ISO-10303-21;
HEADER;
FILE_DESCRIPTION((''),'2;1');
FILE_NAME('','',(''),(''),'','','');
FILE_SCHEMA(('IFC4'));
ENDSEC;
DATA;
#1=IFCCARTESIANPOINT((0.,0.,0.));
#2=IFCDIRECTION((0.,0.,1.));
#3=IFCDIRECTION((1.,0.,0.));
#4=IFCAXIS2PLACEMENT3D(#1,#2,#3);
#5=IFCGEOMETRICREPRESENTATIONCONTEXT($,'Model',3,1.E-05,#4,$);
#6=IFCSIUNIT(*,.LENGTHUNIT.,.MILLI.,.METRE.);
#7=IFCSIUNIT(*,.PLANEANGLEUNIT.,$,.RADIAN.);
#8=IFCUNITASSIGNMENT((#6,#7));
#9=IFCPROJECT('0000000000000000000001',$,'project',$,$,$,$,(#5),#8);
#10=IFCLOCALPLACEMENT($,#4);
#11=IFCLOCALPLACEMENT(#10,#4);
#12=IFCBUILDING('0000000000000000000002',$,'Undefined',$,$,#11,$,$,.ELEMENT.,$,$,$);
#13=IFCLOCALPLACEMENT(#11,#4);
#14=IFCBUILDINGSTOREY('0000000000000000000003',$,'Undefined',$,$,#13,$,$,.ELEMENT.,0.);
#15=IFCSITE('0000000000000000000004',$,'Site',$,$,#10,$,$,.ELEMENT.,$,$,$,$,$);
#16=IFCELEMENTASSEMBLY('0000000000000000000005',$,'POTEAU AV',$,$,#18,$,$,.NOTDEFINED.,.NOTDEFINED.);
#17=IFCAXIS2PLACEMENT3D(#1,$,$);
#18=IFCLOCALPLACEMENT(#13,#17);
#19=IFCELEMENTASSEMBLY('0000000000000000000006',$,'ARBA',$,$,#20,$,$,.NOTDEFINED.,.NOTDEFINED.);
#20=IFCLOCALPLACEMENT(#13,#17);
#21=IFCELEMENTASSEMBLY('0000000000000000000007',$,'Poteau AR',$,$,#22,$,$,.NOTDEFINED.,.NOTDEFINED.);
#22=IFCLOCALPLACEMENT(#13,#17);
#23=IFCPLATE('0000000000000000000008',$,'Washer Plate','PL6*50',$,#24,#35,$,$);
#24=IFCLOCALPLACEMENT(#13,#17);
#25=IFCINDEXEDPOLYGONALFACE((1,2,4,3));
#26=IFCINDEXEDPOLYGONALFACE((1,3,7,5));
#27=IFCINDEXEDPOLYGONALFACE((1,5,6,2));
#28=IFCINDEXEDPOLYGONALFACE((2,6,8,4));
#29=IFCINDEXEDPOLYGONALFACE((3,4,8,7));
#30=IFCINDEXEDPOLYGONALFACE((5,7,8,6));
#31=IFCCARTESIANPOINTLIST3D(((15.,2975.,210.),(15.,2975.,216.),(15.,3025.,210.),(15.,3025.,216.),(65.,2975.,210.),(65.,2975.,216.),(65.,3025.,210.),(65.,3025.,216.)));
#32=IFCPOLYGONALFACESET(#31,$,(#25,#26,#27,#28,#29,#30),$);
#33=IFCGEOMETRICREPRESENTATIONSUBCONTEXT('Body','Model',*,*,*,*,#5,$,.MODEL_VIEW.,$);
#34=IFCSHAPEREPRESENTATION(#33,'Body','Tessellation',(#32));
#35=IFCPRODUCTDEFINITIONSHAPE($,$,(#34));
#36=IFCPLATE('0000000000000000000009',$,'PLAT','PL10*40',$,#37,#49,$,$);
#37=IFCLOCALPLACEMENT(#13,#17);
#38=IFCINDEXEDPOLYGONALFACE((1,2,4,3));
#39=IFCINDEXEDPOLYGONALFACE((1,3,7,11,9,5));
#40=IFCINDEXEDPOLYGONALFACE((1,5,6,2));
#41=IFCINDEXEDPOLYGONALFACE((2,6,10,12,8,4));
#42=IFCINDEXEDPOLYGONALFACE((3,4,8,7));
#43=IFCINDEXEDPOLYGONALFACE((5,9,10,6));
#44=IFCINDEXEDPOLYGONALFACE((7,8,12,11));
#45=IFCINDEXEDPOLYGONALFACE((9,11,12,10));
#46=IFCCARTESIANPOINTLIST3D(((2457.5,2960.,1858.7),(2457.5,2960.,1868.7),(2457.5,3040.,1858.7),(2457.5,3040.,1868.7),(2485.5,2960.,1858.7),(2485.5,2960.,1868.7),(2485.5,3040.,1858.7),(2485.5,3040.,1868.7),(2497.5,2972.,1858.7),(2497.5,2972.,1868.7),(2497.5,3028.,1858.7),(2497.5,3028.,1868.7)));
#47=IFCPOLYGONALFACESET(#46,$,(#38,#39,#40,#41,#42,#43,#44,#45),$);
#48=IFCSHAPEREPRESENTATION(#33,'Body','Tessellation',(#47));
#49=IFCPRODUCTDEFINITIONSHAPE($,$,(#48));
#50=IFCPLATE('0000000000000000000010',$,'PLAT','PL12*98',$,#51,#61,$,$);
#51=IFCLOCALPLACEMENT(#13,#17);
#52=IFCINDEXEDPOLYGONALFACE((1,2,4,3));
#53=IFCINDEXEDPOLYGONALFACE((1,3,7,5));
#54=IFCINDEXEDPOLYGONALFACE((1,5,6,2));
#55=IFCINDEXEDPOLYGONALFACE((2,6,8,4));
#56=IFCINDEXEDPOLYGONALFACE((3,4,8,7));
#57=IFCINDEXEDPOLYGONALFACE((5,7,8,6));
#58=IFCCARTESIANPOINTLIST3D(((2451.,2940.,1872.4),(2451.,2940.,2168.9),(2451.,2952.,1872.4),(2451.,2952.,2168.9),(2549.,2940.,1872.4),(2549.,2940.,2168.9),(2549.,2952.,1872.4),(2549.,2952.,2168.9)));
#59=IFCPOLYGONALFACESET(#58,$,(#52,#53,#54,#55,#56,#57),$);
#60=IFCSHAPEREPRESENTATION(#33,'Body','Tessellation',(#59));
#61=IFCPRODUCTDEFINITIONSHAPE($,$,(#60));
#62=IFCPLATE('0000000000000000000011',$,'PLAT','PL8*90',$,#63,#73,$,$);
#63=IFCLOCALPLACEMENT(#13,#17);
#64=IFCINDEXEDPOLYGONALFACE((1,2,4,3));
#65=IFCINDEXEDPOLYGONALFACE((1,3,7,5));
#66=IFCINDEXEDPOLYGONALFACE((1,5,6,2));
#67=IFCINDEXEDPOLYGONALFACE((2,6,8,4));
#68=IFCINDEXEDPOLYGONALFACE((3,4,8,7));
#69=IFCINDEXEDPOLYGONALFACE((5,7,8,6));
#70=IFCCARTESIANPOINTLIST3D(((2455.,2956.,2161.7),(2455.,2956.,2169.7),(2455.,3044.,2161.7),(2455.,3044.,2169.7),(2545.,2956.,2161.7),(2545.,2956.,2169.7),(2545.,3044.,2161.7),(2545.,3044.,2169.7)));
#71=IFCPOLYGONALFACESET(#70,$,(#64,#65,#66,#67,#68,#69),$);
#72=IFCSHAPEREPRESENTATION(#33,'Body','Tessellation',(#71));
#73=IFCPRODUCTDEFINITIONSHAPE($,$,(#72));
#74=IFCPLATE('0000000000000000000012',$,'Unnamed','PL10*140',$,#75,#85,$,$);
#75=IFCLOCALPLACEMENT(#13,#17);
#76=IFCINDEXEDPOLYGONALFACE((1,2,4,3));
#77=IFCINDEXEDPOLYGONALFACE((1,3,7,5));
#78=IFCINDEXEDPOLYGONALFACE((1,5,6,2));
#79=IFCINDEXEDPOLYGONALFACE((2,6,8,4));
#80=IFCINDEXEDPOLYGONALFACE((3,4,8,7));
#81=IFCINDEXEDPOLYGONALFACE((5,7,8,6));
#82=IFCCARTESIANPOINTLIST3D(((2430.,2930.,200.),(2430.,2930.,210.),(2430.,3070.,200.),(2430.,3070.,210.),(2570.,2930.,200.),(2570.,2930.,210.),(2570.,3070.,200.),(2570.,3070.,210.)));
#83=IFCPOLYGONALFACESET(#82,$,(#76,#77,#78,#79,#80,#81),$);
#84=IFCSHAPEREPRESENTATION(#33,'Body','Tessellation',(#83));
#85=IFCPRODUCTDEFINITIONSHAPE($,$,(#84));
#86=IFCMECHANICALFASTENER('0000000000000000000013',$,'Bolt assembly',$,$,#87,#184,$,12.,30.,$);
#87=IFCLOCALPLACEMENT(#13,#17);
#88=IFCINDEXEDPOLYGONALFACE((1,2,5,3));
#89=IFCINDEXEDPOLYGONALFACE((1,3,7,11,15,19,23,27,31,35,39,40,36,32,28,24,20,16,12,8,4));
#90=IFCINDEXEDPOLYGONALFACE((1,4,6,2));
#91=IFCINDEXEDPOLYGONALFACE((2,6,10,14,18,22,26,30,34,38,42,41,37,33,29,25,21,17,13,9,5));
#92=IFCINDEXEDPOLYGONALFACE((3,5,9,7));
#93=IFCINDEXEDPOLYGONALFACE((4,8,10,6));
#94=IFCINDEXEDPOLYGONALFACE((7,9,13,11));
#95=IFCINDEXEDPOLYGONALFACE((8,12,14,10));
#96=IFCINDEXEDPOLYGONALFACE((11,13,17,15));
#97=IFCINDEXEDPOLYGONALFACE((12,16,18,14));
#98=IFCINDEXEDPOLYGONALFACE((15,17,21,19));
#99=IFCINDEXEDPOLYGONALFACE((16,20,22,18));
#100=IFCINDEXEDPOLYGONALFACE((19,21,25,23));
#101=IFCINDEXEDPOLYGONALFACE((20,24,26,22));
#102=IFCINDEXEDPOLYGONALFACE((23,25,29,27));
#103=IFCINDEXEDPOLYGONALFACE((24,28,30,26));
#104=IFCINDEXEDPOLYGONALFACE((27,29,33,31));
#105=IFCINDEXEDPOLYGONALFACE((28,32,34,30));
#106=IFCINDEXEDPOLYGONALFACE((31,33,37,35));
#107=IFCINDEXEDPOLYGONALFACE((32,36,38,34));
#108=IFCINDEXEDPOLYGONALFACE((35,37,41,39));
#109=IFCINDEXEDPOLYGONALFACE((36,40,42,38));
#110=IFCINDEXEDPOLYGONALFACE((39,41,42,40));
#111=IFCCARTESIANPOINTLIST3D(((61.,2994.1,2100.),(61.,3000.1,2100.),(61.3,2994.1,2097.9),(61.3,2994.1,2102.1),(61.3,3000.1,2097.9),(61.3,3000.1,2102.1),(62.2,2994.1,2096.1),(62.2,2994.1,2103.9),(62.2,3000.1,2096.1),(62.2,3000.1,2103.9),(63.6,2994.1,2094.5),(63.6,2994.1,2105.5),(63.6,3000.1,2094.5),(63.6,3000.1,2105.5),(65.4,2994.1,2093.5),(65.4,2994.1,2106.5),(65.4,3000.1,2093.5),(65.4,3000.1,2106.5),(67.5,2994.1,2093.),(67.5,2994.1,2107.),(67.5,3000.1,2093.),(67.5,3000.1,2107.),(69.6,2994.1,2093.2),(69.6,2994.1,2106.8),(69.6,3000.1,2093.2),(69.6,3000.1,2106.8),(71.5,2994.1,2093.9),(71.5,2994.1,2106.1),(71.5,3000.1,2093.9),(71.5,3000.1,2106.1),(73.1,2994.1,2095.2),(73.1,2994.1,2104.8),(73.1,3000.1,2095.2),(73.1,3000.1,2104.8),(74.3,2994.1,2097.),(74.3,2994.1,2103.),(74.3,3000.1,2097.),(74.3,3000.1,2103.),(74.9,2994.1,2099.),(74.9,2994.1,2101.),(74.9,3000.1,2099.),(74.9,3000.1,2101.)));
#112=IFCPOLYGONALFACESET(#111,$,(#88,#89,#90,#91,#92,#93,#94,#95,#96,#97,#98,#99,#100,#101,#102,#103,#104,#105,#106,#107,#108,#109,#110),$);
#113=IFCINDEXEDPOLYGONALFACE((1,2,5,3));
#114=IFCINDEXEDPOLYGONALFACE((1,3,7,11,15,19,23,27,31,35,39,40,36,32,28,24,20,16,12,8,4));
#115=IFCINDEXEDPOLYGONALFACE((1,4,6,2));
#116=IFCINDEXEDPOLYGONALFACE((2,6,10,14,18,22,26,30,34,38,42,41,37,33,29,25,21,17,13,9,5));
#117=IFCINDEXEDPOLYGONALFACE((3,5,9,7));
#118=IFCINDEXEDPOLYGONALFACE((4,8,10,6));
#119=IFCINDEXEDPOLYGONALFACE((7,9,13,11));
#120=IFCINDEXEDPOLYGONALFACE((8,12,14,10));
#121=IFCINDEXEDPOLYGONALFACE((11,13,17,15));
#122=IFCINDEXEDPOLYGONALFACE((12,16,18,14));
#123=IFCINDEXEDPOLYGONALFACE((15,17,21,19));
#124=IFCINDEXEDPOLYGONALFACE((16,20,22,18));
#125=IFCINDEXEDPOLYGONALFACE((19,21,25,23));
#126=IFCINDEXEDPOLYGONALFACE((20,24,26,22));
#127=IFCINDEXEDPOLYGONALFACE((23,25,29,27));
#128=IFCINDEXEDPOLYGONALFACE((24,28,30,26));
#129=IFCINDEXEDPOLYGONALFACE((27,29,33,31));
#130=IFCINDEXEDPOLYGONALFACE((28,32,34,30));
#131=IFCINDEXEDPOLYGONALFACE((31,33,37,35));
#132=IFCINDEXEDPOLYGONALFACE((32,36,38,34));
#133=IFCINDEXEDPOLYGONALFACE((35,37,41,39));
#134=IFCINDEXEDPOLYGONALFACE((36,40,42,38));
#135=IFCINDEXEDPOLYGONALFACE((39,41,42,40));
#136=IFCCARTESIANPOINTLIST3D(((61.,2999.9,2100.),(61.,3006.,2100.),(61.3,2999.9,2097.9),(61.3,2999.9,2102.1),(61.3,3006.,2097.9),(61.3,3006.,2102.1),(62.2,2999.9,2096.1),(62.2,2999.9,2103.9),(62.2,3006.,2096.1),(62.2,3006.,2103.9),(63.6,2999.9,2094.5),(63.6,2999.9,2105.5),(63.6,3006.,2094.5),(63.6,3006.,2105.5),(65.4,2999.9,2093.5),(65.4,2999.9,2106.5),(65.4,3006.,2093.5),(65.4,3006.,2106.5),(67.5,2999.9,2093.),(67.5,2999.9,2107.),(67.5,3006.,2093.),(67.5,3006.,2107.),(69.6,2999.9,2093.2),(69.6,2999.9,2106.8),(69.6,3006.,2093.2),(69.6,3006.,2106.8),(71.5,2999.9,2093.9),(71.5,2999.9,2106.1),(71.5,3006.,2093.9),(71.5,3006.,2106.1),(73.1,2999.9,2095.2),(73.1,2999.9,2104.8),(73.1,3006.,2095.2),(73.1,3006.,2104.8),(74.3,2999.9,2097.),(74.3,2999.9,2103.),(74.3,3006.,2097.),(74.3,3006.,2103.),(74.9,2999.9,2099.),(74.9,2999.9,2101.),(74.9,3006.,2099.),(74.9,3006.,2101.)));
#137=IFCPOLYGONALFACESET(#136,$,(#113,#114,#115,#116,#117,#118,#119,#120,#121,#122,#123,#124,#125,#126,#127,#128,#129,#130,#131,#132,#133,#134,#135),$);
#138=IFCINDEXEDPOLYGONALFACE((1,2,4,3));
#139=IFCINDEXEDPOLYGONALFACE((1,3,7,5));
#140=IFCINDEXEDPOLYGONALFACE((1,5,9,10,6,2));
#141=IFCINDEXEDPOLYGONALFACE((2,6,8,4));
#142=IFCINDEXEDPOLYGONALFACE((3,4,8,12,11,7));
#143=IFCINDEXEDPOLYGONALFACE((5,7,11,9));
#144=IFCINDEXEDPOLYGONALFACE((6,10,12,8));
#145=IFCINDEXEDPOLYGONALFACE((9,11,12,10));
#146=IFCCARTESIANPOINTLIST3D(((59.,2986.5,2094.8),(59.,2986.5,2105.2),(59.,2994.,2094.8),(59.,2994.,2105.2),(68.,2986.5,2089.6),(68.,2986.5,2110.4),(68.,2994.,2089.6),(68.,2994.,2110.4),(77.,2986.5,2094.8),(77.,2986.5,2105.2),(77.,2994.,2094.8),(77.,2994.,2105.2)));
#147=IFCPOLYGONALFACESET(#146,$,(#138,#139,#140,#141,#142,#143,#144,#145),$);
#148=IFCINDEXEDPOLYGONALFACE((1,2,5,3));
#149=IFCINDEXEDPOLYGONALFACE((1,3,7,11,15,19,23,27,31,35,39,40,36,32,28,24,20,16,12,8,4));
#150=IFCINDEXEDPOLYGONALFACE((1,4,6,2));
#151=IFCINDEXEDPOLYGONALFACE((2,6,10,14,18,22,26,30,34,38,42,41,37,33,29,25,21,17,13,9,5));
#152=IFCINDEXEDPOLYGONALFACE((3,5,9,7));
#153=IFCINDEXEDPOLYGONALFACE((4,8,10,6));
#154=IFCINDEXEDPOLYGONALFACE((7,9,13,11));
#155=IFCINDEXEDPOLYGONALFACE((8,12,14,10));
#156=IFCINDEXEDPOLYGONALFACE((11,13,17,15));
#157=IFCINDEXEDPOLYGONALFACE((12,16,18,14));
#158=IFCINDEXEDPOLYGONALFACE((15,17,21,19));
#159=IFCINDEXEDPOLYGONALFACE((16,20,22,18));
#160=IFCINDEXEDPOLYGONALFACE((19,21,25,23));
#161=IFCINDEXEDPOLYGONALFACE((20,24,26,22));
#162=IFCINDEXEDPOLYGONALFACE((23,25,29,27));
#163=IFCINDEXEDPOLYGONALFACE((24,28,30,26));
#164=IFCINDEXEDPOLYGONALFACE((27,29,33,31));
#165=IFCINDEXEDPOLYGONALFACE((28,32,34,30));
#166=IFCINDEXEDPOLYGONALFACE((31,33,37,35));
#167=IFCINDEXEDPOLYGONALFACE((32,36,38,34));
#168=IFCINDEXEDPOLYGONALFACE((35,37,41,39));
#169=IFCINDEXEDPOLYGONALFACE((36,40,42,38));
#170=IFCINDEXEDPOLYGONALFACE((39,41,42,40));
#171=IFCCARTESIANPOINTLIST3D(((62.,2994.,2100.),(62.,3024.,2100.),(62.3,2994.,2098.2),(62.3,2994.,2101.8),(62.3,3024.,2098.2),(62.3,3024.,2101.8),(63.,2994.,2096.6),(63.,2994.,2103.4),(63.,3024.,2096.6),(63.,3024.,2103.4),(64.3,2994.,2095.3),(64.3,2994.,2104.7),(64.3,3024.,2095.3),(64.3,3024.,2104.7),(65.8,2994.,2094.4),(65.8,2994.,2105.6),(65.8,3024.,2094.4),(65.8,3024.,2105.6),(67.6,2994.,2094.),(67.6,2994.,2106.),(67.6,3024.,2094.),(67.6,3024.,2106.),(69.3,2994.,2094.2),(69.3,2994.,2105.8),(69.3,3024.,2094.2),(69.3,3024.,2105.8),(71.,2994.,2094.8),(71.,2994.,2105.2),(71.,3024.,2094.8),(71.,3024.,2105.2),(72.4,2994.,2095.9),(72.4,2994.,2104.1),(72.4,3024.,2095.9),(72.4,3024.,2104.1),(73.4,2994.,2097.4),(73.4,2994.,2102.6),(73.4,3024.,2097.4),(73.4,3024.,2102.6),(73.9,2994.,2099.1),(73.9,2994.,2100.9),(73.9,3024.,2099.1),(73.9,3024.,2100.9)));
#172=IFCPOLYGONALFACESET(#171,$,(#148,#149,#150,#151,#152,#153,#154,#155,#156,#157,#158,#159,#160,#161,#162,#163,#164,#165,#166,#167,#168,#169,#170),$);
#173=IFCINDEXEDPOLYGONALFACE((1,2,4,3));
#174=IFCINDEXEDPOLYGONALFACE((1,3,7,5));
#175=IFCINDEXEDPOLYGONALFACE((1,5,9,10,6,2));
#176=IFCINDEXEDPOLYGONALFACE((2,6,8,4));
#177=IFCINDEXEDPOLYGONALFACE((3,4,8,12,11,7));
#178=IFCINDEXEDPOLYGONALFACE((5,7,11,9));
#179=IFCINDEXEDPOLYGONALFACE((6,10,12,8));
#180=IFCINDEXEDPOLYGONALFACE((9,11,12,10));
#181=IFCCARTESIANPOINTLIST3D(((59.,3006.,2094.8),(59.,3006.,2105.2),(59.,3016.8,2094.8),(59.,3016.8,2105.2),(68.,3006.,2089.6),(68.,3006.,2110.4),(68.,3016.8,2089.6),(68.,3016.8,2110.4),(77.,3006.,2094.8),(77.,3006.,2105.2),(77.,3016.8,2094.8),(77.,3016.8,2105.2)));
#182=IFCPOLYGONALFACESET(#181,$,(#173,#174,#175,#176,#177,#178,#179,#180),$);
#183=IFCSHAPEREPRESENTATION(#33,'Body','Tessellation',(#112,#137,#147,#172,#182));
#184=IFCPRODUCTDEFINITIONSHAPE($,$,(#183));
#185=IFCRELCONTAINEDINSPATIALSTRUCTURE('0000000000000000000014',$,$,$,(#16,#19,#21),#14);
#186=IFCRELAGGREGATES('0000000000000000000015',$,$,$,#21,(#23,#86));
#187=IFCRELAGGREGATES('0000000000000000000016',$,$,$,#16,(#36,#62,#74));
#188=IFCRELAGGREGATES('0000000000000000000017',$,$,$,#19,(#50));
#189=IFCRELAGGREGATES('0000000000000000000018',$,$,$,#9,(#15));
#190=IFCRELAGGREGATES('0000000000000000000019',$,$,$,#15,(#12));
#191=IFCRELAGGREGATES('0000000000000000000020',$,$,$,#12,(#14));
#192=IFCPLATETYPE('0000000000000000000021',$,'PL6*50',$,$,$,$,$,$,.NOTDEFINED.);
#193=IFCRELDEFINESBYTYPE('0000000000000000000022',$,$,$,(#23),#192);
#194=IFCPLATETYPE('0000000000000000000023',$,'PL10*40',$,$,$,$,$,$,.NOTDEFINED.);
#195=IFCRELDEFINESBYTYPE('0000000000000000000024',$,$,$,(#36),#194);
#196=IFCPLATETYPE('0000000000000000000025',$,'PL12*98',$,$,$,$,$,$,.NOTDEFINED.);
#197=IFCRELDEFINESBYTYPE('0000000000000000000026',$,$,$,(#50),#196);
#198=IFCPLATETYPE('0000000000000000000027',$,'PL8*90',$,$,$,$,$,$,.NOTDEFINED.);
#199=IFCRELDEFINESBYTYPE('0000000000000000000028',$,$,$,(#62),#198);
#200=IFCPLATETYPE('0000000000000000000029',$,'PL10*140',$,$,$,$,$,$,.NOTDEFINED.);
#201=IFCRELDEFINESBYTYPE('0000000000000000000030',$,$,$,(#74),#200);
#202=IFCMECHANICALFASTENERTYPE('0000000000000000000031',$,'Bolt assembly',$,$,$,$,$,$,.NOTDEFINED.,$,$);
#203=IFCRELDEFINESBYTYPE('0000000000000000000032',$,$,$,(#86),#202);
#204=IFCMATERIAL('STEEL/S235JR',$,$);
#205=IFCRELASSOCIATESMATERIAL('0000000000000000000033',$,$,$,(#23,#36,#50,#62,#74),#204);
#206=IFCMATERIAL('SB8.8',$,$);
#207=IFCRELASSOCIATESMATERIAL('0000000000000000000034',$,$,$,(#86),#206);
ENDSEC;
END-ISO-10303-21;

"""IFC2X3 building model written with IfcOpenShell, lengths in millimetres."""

from ifc_helpers import new_model, si_unit, frame, origin_with_axes, origin_2d_with_axis, place, context, subcontext, project, spatial, polyline, circle, outline, extrude, source, transform, mapped, material, type_object, element, aggregate, save


model = new_model("IFC2X3")

# Units and contexts
model_context = context("Model", 3, precision=1e-05, world=origin_with_axes())
body_context = subcontext(model_context, "Body", "Model", "MODEL_VIEW")
ifc_project = project(units=[si_unit("LENGTHUNIT", "METRE", prefix="MILLI"), si_unit("PLANEANGLEUNIT", "RADIAN")], contexts=[model_context])

# Site, building, storey
site_placement = place(None, origin_with_axes())
site = spatial("IfcSite", under=ifc_project, at=site_placement, Name="Site", CompositionType="ELEMENT")
building_placement = place(site_placement, origin_with_axes())
building = spatial("IfcBuilding", under=site, at=building_placement, Name="Undefined", CompositionType="ELEMENT")
storey_placement = place(building_placement, origin_with_axes())
storey = spatial("IfcBuildingStorey", under=building, at=storey_placement, Name="Undefined", CompositionType="ELEMENT", Elevation=0.0)

# Element assembly
ifc_material_1 = material(Name="STEEL/S235JR")
assembly_1_placement = place(storey_placement, origin_with_axes())
assembly_1 = element("IfcElementAssembly", 1, at=assembly_1_placement, inside=storey, Name="POTEAU AV", AssemblyPlace="NOTDEFINED", PredefinedType="NOTDEFINED")

# Element assembly
assembly_2_placement = place(storey_placement, origin_with_axes())
assembly_2 = element("IfcElementAssembly", 2, at=assembly_2_placement, inside=storey, Name="ARBA", AssemblyPlace="NOTDEFINED", PredefinedType="NOTDEFINED")

# Element assembly
assembly_3_placement = place(storey_placement, origin_with_axes())
assembly_3 = element("IfcElementAssembly", 3, at=assembly_3_placement, inside=storey, Name="Poteau AR", AssemblyPlace="NOTDEFINED", PredefinedType="NOTDEFINED")

# Shared definitions
plate_type_1 = type_object("IfcPlateType", Name="PL6*50", PredefinedType="NOTDEFINED")

# Plates
plate_1_placement = place(assembly_3_placement, frame((65.0, 3025.0, 213.0), z_axis=(0.0, 0.0, -1.0), x_axis=(0.0, -1.0, 0.0)))
plate_1 = element("IfcPlate", 4, at=plate_1_placement, type_object=plate_type_1, material=ifc_material_1, Name="Washer Plate", Description="PL6*50", context=body_context, shape_type="SweptSolid", body=[
    extrude(outline(polyline([(0.0, 0.0), (50.0, 0.0), (50.0, 50.0), (0.0, 50.0), (0.0, 0.0)])), frame((0.0, 0.0, -3.0), z_axis=(0.0, 0.0, 1.0), x_axis=(1.0, 0.0, 0.0)), (0.0, 0.0, 1.0), 6.0),
])
plate_type_2 = type_object("IfcPlateType", Name="PL10*40", PredefinedType="NOTDEFINED")
plate_2_placement = place(assembly_1_placement, frame((2457.5, 2960.0, 1863.7), z_axis=(0.0, 0.0, 1.0), x_axis=(1.0, 0.0, 0.0)))
plate_2 = element("IfcPlate", 5, at=plate_2_placement, type_object=plate_type_2, material=ifc_material_1, Name="PLAT", Description="PL10*40", context=body_context, shape_type="SweptSolid", body=[
    extrude(outline(polyline([(0.0, 0.0), (28.0, 0.0), (40.0, 12.0), (40.0, 68.0), (28.0, 80.0), (0.0, 80.0), (0.0, 0.0)])), frame((0.0, 0.0, -5.0), z_axis=(0.0, 0.0, 1.0), x_axis=(1.0, 0.0, 0.0)), (0.0, 0.0, 1.0), 10.0),
])
plate_type_3 = type_object("IfcPlateType", Name="PL12*98", PredefinedType="NOTDEFINED")
plate_3_placement = place(assembly_2_placement, frame((2500.0, 2946.0, 1872.4), z_axis=(0.0, -1.0, 0.0), x_axis=(0.0, 0.0, 1.0)))
plate_3 = element("IfcPlate", 6, at=plate_3_placement, type_object=plate_type_3, material=ifc_material_1, Name="PLAT", Description="PL12*98", context=body_context, shape_type="SweptSolid", body=[
    extrude(outline(polyline([(0.0, 49.0), (296.4, 49.0), (296.4, -49.0), (0.0, -49.0), (0.0, 49.0)])), frame((0.0, 0.0, -6.0), z_axis=(0.0, 0.0, 1.0), x_axis=(1.0, 0.0, 0.0)), (0.0, 0.0, 1.0), 12.0),
])
plate_type_4 = type_object("IfcPlateType", Name="PL8*90", PredefinedType="NOTDEFINED")
plate_4_placement = place(assembly_1_placement, frame((2500.0, 3044.0, 2165.7), z_axis=(0.0, 0.0, -1.0), x_axis=(0.0, -1.0, 0.0)))
plate_4 = element("IfcPlate", 7, at=plate_4_placement, type_object=plate_type_4, material=ifc_material_1, Name="PLAT", Description="PL8*90", context=body_context, shape_type="SweptSolid", body=[
    extrude(outline(polyline([(88.0, 45.0), (88.0, -45.0), (0.0, -45.0), (0.0, 45.0), (88.0, 45.0)])), frame((0.0, 0.0, -4.0), z_axis=(0.0, 0.0, 1.0), x_axis=(1.0, 0.0, 0.0)), (0.0, 0.0, 1.0), 8.0),
])
plate_type_5 = type_object("IfcPlateType", Name="PL10*140", PredefinedType="NOTDEFINED")
plate_5_placement = place(assembly_1_placement, frame((2500.0, 2930.0, 205.0), z_axis=(0.0, 0.0, 1.0), x_axis=(0.0, 1.0, 0.0)))
plate_5 = element("IfcPlate", 8, at=plate_5_placement, type_object=plate_type_5, material=ifc_material_1, Name="Unnamed", Description="PL10*140", context=body_context, shape_type="SweptSolid", body=[
    extrude(outline(polyline([(0.0, 70.0), (140.0, 70.0), (140.0, -70.0), (0.0, -70.0), (0.0, 70.0)])), frame((0.0, 0.0, -5.0), z_axis=(0.0, 0.0, 1.0), x_axis=(1.0, 0.0, 0.0)), (0.0, 0.0, 1.0), 10.0),
])

# Mechanical fastener
ifc_material_2 = material(Name="SB8.8")
mechanical_fastener_type = type_object("IfcMechanicalFastenerType", Name="Bolt assembly")
shared_shape_1 = source(origin_with_axes(), body_context, "Body", "SweptSolid", [
    extrude(circle(Radius=7.0, at=origin_2d_with_axis()), frame((0.0, -8.9, 0.0), z_axis=(0.0, 1.0, 0.0), x_axis=(1.0, 0.0, 0.0)), (0.0, 0.0, 1.0), 6.0),
    extrude(circle(Radius=7.0, at=origin_2d_with_axis()), frame((0.0, -3.1, 0.0), z_axis=(0.0, 1.0, 0.0), x_axis=(1.0, 0.0, 0.0)), (0.0, 0.0, 1.0), 6.1),
    extrude(outline(polyline([(9.0, -5.2), (9.0, 5.2), (0.0, 10.4), (-9.0, 5.2), (-9.0, -5.2), (0.0, -10.4), (9.0, -5.2)])), frame((0.0, -16.5, 0.0), z_axis=(0.0, 1.0, 0.0), x_axis=(1.0, 0.0, 0.0)), (0.0, 0.0, 1.0), 7.5),
    extrude(circle(Radius=6.0, at=origin_2d_with_axis()), frame((0.0, -9.0, 0.0), z_axis=(0.0, 1.0, 0.0), x_axis=(1.0, 0.0, 0.0)), (0.0, 0.0, 1.0), 30.0),
    extrude(outline(polyline([(9.0, -5.2), (9.0, 5.2), (0.0, 10.4), (-9.0, 5.2), (-9.0, -5.2), (0.0, -10.4), (9.0, -5.2)])), frame((0.0, 3.0, 0.0), z_axis=(0.0, 1.0, 0.0), x_axis=(1.0, 0.0, 0.0)), (0.0, 0.0, 1.0), 10.8),
])
mechanical_fastener_1_placement = place(assembly_3_placement, frame((68.0, 3003.0, 2100.0), z_axis=(0.0, 0.0, -1.0), x_axis=(-1.0, 0.0, 0.0)))
mechanical_fastener_1 = element("IfcMechanicalFastener", 9, at=mechanical_fastener_1_placement, type_object=mechanical_fastener_type, material=ifc_material_2, Name="Bolt assembly", NominalDiameter=12.0, NominalLength=30.0, context=body_context, shape_type="MappedRepresentation", body=[
    mapped(shared_shape_1, transform((0.0, 0.0, 0.0))),
])
aggregate(assembly_3, [plate_1, mechanical_fastener_1])
aggregate(assembly_1, [plate_2, plate_4, plate_5])
aggregate(assembly_2, [plate_3])

save(model, "model.ifc")
